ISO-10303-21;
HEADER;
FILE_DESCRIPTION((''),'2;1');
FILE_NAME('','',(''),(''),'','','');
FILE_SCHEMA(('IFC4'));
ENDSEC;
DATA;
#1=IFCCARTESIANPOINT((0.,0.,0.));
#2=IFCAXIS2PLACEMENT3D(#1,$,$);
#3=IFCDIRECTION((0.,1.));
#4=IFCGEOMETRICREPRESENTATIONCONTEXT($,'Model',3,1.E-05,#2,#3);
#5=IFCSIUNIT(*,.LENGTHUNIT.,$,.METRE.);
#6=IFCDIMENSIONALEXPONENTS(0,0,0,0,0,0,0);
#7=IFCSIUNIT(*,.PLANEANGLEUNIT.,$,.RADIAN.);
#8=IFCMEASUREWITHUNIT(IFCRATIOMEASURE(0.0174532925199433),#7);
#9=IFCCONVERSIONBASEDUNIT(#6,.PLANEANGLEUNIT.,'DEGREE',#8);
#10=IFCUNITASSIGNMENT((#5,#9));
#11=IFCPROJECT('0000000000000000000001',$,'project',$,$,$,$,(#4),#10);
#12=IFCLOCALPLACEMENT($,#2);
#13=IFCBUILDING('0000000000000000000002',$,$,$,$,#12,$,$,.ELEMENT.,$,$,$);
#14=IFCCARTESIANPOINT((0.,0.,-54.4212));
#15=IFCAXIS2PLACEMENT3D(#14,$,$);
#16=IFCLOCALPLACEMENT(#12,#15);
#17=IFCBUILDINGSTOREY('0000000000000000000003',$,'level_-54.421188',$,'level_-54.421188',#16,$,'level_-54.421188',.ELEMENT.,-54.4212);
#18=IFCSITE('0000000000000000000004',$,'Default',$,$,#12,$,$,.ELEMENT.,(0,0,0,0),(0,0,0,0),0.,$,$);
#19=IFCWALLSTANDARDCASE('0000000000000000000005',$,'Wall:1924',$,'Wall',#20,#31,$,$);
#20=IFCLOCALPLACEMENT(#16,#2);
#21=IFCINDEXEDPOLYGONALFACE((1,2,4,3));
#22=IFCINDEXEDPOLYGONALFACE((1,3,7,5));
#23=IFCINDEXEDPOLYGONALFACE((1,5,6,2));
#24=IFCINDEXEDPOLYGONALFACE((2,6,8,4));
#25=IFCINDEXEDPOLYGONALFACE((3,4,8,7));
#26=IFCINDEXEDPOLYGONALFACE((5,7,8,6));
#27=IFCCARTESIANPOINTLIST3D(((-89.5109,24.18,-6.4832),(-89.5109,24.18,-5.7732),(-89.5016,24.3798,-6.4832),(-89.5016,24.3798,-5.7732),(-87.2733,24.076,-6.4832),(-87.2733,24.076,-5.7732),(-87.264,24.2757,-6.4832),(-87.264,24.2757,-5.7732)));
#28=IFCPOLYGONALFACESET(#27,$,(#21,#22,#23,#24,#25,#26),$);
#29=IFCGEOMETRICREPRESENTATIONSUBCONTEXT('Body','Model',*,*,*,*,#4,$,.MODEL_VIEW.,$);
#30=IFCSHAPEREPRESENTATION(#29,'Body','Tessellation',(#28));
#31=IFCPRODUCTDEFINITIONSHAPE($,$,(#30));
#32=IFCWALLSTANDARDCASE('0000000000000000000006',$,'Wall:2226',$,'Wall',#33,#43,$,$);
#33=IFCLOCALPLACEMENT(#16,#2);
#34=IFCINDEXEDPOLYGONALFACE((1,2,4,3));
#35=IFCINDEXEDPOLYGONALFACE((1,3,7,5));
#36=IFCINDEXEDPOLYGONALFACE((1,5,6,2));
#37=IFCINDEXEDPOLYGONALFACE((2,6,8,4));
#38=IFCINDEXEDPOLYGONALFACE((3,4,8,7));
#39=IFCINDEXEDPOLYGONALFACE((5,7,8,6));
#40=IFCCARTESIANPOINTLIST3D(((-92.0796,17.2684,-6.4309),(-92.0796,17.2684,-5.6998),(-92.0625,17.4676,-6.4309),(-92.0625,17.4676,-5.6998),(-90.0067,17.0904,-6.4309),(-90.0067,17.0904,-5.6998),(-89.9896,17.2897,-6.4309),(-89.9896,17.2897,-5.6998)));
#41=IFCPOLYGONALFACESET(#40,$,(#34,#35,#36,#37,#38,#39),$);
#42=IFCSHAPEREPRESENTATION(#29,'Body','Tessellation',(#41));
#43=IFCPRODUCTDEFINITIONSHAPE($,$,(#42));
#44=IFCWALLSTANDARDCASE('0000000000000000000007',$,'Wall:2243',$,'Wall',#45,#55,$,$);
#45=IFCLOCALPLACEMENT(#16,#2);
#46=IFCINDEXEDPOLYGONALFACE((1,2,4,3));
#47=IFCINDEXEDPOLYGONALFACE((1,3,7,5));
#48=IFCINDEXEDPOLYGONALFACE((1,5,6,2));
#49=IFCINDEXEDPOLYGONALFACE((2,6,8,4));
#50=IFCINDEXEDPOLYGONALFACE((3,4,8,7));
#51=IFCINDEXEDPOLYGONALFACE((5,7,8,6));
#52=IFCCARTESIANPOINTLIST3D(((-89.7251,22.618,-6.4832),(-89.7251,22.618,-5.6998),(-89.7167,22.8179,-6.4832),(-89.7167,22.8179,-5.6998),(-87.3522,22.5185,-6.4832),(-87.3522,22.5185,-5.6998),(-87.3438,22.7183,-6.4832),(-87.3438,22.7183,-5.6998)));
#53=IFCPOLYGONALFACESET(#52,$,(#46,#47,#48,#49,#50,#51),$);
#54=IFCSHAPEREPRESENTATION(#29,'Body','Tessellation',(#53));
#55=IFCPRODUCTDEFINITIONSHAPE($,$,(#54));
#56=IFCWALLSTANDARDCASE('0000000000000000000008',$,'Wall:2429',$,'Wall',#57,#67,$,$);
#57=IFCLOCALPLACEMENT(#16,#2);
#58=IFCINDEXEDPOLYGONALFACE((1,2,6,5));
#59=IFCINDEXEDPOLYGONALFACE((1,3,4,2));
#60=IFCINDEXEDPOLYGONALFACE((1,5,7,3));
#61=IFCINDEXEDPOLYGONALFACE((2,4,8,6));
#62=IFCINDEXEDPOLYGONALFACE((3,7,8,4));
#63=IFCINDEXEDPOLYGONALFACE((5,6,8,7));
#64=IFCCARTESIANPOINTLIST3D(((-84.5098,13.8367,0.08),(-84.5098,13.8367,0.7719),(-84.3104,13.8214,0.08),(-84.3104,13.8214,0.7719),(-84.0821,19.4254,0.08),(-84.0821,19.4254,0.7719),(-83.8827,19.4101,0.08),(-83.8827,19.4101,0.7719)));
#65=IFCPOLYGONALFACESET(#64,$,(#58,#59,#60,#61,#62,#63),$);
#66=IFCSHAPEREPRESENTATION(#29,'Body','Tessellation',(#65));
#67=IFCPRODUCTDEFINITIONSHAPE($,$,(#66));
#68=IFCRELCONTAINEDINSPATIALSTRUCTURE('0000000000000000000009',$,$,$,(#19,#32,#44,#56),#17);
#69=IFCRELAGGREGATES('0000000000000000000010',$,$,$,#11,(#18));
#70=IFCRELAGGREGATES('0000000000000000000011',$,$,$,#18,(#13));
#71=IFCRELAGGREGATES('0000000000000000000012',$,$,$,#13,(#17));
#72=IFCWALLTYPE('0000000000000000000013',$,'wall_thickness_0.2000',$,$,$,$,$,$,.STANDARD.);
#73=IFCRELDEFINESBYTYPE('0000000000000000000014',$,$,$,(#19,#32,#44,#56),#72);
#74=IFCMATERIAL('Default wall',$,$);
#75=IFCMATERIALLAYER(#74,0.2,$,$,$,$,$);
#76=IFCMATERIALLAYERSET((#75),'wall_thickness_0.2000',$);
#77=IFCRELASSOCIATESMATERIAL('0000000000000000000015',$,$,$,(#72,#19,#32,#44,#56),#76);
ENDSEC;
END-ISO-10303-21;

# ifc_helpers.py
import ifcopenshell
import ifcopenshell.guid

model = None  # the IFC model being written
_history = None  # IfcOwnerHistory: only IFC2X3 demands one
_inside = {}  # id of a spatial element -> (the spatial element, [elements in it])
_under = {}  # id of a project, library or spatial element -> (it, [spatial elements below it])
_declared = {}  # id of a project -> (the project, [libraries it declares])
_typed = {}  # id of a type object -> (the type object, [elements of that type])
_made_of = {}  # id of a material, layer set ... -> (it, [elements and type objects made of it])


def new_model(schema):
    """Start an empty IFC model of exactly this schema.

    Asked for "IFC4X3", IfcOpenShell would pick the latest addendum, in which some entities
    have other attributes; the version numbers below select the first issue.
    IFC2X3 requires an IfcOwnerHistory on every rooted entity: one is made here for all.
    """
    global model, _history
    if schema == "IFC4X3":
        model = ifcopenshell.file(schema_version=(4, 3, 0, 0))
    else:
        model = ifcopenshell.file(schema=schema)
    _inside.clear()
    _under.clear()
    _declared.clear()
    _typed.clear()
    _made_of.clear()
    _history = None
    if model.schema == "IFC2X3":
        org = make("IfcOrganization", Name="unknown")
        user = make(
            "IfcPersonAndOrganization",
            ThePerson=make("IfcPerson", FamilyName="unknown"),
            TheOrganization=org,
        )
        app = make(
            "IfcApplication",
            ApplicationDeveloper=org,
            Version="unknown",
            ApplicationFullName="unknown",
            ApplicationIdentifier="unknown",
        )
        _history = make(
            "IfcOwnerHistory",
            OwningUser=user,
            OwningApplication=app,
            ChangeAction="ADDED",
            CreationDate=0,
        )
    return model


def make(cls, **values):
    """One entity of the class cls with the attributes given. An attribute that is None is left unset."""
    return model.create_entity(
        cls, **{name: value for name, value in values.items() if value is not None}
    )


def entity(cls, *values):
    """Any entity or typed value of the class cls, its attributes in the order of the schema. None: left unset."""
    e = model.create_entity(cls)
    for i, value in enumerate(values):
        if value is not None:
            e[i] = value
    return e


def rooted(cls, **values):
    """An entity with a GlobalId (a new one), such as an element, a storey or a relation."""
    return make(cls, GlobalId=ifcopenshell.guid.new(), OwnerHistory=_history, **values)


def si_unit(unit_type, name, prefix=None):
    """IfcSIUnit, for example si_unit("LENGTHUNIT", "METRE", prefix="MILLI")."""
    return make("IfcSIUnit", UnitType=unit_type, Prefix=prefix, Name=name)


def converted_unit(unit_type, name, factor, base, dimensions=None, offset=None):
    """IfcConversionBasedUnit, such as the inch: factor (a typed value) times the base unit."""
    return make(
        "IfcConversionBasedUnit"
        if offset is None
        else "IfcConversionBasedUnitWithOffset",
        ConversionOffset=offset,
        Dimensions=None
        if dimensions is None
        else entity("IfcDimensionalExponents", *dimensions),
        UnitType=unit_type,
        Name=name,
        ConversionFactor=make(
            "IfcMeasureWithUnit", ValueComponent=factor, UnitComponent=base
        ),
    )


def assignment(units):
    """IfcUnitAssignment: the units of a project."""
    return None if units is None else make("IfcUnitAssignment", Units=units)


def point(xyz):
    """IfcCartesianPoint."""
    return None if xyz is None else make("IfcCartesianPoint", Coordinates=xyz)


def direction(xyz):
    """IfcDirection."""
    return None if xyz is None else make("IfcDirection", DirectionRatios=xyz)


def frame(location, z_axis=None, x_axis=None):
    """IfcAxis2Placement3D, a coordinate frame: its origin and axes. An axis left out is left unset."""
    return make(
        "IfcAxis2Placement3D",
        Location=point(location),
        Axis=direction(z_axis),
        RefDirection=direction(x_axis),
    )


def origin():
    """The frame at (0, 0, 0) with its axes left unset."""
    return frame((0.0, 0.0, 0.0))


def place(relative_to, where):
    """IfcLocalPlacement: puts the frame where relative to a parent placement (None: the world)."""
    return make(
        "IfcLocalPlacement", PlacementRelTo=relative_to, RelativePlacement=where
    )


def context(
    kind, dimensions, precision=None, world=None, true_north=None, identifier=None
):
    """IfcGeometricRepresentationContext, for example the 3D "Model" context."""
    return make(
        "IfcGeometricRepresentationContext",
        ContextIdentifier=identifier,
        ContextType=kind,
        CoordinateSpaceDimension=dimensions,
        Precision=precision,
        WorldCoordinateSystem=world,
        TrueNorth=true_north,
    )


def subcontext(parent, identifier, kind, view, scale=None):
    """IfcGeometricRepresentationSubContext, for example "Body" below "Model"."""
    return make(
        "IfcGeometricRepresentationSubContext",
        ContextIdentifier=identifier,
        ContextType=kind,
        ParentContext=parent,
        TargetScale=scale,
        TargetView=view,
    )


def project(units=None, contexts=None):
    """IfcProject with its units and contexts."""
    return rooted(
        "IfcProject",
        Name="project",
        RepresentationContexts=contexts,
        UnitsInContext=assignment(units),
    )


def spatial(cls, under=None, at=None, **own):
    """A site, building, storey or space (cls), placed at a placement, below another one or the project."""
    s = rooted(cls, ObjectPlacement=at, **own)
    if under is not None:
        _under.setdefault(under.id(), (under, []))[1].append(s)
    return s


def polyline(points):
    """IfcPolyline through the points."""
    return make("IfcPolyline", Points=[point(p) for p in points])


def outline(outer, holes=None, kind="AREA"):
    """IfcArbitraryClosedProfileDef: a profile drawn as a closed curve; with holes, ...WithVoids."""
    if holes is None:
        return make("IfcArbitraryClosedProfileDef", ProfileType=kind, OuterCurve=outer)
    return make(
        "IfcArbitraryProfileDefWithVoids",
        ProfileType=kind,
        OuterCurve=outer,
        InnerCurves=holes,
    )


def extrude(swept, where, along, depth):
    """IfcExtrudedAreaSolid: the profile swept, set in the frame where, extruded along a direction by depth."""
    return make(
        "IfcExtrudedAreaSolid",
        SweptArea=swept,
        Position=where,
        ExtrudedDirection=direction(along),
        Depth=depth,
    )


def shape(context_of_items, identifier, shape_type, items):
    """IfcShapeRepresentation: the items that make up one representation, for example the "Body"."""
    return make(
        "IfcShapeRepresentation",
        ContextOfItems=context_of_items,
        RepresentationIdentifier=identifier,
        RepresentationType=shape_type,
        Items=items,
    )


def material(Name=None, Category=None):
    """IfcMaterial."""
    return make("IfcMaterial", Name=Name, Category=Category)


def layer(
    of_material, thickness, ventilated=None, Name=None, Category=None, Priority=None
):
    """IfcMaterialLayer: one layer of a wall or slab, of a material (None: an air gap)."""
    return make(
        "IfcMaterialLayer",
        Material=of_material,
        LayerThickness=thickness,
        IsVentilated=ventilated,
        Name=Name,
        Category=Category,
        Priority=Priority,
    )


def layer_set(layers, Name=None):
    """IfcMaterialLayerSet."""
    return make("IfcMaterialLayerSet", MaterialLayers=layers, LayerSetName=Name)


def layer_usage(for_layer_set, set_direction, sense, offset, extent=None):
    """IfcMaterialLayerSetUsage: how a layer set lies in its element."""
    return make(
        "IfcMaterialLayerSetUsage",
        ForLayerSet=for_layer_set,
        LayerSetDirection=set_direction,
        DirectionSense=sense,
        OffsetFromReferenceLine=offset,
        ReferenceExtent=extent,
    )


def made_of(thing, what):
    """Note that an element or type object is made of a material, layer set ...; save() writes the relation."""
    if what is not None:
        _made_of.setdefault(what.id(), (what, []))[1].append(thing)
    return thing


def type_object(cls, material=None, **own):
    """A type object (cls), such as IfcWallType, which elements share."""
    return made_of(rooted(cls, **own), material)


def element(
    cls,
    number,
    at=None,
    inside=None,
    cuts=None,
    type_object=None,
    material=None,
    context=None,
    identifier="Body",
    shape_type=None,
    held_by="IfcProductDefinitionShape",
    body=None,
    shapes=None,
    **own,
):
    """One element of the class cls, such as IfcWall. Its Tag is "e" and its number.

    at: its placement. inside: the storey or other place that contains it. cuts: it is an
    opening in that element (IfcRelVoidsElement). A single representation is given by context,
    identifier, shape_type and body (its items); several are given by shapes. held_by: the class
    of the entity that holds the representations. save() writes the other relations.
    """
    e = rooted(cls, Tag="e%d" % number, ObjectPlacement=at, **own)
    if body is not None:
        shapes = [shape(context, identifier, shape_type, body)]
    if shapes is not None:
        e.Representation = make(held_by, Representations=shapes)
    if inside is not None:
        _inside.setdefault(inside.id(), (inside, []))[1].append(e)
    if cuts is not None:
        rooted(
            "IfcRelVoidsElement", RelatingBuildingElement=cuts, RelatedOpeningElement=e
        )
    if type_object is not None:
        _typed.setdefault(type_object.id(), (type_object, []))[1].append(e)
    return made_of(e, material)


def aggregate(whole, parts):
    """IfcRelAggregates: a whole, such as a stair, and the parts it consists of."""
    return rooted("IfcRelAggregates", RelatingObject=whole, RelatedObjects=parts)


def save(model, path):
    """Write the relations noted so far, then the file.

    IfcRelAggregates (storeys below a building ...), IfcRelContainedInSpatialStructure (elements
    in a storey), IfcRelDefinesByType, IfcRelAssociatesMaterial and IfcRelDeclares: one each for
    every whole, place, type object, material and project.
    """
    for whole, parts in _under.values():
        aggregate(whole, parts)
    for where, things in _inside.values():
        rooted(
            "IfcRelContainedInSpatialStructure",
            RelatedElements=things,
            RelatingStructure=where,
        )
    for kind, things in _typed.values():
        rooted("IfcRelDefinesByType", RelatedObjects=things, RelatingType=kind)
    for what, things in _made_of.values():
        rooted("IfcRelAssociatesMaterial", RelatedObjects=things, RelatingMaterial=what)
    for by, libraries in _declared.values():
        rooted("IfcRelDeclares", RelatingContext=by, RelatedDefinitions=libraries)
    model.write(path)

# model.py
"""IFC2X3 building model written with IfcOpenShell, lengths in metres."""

from ifc_helpers import new_model, entity, si_unit, converted_unit, direction, frame, origin, place, context, subcontext, project, spatial, polyline, outline, extrude, material, layer, layer_set, layer_usage, type_object, element, save


model = new_model("IFC2X3")

# Units and contexts
model_context = context("Model", 3, precision=1e-05, world=origin(), true_north=direction((0.0, 1.0)))
body_context = subcontext(model_context, "Body", "Model", "MODEL_VIEW")
ifc_project = project(units=[si_unit("LENGTHUNIT", "METRE"), converted_unit("PLANEANGLEUNIT", "DEGREE", entity("IfcRatioMeasure", 0.0174532925199433), si_unit("PLANEANGLEUNIT", "RADIAN"), dimensions=[0, 0, 0, 0, 0, 0, 0])], contexts=[model_context])

# Site, building, storey
placement_1 = place(None, origin())
site = spatial("IfcSite", under=ifc_project, at=placement_1, Name="Default", CompositionType="ELEMENT", RefLatitude=(0, 0, 0, 0), RefLongitude=(0, 0, 0, 0), RefElevation=0.0)
building = spatial("IfcBuilding", under=site, at=placement_1, CompositionType="ELEMENT")
storey_placement = place(placement_1, frame((0.0, 0.0, -54.4212)))
storey = spatial("IfcBuildingStorey", under=building, at=storey_placement, Name="level_-54.421188", ObjectType="level_-54.421188", LongName="level_-54.421188", CompositionType="ELEMENT", Elevation=-54.4212)

# Shared definitions
ifc_material_1 = material(Name="Default wall")
ifc_layer = layer(ifc_material_1, 0.2)
ifc_layer_set = layer_set([ifc_layer], Name="wall_thickness_0.2000")
ifc_layer_usage = layer_usage(ifc_layer_set, "AXIS2", "POSITIVE", -0.1)
wall_type = type_object("IfcWallType", Name="wall_thickness_0.2000", PredefinedType="STANDARD", material=ifc_layer_set)

# Walls
placement_2 = place(placement_1, frame((0.0, 0.0, -60.9044)))
wall_1_placement = place(placement_2, frame((-89.5063, 24.2799, 0.0), z_axis=(0.0, 0.0, 1.0), x_axis=(0.99892, -0.046467, 0.0)))
element("IfcWallStandardCase", 1, at=wall_1_placement, inside=storey, type_object=wall_type, material=ifc_layer_usage, Name="Wall:1924", ObjectType="Wall", context=body_context, shape_type="SweptSolid", body=[
    extrude(outline(polyline([(2.24, -0.1), (2.24, 0.1), (0.0, 0.1), (0.0, -0.1), (2.24, -0.1)])), origin(), (0.0, 0.0, 1.0), 0.7101),
])
placement_3 = place(placement_1, frame((0.0, 0.0, -60.8521)))
wall_2_placement = place(placement_3, frame((-92.071, 17.368, 0.0), z_axis=(0.0, 0.0, 1.0), x_axis=(0.996337, -0.085513, 0.0)))
element("IfcWallStandardCase", 2, at=wall_2_placement, inside=storey, type_object=wall_type, material=ifc_layer_usage, Name="Wall:2226", ObjectType="Wall", context=body_context, shape_type="SweptSolid", body=[
    extrude(outline(polyline([(2.0805, -0.1), (2.0805, 0.1), (0.0, 0.1), (0.0, -0.1), (2.0805, -0.1)])), origin(), (0.0, 0.0, 1.0), 0.7311),
])
placement_4 = place(placement_1, frame((0.0, 0.0, -60.9044)))
wall_3_placement = place(placement_4, frame((-89.7209, 22.7179, 0.0), z_axis=(0.0, 0.0, 1.0), x_axis=(0.999121, -0.041915, 0.0)))
element("IfcWallStandardCase", 3, at=wall_3_placement, inside=storey, type_object=wall_type, material=ifc_layer_usage, Name="Wall:2243", ObjectType="Wall", context=body_context, shape_type="SweptSolid", body=[
    extrude(outline(polyline([(2.375, -0.1), (2.375, 0.1), (0.0, 0.1), (0.0, -0.1), (2.375, -0.1)])), origin(), (0.0, 0.0, 1.0), 0.7835),
])
placement_5 = place(placement_1, frame((0.0, 0.0, -54.3412)))
wall_4_placement = place(placement_5, frame((-84.4101, 13.8291, 0.0), z_axis=(0.0, 0.0, 1.0), x_axis=(0.076308, 0.997084, 0.0)))
element("IfcWallStandardCase", 4, at=wall_4_placement, inside=storey, type_object=wall_type, material=ifc_layer_usage, Name="Wall:2429", ObjectType="Wall", context=body_context, shape_type="SweptSolid", body=[
    extrude(outline(polyline([(5.605, -0.1), (5.605, 0.1), (0.0, 0.1), (0.0, -0.1), (5.605, -0.1)])), origin(), (0.0, 0.0, 1.0), 0.692),
])

save(model, "model.ifc")
